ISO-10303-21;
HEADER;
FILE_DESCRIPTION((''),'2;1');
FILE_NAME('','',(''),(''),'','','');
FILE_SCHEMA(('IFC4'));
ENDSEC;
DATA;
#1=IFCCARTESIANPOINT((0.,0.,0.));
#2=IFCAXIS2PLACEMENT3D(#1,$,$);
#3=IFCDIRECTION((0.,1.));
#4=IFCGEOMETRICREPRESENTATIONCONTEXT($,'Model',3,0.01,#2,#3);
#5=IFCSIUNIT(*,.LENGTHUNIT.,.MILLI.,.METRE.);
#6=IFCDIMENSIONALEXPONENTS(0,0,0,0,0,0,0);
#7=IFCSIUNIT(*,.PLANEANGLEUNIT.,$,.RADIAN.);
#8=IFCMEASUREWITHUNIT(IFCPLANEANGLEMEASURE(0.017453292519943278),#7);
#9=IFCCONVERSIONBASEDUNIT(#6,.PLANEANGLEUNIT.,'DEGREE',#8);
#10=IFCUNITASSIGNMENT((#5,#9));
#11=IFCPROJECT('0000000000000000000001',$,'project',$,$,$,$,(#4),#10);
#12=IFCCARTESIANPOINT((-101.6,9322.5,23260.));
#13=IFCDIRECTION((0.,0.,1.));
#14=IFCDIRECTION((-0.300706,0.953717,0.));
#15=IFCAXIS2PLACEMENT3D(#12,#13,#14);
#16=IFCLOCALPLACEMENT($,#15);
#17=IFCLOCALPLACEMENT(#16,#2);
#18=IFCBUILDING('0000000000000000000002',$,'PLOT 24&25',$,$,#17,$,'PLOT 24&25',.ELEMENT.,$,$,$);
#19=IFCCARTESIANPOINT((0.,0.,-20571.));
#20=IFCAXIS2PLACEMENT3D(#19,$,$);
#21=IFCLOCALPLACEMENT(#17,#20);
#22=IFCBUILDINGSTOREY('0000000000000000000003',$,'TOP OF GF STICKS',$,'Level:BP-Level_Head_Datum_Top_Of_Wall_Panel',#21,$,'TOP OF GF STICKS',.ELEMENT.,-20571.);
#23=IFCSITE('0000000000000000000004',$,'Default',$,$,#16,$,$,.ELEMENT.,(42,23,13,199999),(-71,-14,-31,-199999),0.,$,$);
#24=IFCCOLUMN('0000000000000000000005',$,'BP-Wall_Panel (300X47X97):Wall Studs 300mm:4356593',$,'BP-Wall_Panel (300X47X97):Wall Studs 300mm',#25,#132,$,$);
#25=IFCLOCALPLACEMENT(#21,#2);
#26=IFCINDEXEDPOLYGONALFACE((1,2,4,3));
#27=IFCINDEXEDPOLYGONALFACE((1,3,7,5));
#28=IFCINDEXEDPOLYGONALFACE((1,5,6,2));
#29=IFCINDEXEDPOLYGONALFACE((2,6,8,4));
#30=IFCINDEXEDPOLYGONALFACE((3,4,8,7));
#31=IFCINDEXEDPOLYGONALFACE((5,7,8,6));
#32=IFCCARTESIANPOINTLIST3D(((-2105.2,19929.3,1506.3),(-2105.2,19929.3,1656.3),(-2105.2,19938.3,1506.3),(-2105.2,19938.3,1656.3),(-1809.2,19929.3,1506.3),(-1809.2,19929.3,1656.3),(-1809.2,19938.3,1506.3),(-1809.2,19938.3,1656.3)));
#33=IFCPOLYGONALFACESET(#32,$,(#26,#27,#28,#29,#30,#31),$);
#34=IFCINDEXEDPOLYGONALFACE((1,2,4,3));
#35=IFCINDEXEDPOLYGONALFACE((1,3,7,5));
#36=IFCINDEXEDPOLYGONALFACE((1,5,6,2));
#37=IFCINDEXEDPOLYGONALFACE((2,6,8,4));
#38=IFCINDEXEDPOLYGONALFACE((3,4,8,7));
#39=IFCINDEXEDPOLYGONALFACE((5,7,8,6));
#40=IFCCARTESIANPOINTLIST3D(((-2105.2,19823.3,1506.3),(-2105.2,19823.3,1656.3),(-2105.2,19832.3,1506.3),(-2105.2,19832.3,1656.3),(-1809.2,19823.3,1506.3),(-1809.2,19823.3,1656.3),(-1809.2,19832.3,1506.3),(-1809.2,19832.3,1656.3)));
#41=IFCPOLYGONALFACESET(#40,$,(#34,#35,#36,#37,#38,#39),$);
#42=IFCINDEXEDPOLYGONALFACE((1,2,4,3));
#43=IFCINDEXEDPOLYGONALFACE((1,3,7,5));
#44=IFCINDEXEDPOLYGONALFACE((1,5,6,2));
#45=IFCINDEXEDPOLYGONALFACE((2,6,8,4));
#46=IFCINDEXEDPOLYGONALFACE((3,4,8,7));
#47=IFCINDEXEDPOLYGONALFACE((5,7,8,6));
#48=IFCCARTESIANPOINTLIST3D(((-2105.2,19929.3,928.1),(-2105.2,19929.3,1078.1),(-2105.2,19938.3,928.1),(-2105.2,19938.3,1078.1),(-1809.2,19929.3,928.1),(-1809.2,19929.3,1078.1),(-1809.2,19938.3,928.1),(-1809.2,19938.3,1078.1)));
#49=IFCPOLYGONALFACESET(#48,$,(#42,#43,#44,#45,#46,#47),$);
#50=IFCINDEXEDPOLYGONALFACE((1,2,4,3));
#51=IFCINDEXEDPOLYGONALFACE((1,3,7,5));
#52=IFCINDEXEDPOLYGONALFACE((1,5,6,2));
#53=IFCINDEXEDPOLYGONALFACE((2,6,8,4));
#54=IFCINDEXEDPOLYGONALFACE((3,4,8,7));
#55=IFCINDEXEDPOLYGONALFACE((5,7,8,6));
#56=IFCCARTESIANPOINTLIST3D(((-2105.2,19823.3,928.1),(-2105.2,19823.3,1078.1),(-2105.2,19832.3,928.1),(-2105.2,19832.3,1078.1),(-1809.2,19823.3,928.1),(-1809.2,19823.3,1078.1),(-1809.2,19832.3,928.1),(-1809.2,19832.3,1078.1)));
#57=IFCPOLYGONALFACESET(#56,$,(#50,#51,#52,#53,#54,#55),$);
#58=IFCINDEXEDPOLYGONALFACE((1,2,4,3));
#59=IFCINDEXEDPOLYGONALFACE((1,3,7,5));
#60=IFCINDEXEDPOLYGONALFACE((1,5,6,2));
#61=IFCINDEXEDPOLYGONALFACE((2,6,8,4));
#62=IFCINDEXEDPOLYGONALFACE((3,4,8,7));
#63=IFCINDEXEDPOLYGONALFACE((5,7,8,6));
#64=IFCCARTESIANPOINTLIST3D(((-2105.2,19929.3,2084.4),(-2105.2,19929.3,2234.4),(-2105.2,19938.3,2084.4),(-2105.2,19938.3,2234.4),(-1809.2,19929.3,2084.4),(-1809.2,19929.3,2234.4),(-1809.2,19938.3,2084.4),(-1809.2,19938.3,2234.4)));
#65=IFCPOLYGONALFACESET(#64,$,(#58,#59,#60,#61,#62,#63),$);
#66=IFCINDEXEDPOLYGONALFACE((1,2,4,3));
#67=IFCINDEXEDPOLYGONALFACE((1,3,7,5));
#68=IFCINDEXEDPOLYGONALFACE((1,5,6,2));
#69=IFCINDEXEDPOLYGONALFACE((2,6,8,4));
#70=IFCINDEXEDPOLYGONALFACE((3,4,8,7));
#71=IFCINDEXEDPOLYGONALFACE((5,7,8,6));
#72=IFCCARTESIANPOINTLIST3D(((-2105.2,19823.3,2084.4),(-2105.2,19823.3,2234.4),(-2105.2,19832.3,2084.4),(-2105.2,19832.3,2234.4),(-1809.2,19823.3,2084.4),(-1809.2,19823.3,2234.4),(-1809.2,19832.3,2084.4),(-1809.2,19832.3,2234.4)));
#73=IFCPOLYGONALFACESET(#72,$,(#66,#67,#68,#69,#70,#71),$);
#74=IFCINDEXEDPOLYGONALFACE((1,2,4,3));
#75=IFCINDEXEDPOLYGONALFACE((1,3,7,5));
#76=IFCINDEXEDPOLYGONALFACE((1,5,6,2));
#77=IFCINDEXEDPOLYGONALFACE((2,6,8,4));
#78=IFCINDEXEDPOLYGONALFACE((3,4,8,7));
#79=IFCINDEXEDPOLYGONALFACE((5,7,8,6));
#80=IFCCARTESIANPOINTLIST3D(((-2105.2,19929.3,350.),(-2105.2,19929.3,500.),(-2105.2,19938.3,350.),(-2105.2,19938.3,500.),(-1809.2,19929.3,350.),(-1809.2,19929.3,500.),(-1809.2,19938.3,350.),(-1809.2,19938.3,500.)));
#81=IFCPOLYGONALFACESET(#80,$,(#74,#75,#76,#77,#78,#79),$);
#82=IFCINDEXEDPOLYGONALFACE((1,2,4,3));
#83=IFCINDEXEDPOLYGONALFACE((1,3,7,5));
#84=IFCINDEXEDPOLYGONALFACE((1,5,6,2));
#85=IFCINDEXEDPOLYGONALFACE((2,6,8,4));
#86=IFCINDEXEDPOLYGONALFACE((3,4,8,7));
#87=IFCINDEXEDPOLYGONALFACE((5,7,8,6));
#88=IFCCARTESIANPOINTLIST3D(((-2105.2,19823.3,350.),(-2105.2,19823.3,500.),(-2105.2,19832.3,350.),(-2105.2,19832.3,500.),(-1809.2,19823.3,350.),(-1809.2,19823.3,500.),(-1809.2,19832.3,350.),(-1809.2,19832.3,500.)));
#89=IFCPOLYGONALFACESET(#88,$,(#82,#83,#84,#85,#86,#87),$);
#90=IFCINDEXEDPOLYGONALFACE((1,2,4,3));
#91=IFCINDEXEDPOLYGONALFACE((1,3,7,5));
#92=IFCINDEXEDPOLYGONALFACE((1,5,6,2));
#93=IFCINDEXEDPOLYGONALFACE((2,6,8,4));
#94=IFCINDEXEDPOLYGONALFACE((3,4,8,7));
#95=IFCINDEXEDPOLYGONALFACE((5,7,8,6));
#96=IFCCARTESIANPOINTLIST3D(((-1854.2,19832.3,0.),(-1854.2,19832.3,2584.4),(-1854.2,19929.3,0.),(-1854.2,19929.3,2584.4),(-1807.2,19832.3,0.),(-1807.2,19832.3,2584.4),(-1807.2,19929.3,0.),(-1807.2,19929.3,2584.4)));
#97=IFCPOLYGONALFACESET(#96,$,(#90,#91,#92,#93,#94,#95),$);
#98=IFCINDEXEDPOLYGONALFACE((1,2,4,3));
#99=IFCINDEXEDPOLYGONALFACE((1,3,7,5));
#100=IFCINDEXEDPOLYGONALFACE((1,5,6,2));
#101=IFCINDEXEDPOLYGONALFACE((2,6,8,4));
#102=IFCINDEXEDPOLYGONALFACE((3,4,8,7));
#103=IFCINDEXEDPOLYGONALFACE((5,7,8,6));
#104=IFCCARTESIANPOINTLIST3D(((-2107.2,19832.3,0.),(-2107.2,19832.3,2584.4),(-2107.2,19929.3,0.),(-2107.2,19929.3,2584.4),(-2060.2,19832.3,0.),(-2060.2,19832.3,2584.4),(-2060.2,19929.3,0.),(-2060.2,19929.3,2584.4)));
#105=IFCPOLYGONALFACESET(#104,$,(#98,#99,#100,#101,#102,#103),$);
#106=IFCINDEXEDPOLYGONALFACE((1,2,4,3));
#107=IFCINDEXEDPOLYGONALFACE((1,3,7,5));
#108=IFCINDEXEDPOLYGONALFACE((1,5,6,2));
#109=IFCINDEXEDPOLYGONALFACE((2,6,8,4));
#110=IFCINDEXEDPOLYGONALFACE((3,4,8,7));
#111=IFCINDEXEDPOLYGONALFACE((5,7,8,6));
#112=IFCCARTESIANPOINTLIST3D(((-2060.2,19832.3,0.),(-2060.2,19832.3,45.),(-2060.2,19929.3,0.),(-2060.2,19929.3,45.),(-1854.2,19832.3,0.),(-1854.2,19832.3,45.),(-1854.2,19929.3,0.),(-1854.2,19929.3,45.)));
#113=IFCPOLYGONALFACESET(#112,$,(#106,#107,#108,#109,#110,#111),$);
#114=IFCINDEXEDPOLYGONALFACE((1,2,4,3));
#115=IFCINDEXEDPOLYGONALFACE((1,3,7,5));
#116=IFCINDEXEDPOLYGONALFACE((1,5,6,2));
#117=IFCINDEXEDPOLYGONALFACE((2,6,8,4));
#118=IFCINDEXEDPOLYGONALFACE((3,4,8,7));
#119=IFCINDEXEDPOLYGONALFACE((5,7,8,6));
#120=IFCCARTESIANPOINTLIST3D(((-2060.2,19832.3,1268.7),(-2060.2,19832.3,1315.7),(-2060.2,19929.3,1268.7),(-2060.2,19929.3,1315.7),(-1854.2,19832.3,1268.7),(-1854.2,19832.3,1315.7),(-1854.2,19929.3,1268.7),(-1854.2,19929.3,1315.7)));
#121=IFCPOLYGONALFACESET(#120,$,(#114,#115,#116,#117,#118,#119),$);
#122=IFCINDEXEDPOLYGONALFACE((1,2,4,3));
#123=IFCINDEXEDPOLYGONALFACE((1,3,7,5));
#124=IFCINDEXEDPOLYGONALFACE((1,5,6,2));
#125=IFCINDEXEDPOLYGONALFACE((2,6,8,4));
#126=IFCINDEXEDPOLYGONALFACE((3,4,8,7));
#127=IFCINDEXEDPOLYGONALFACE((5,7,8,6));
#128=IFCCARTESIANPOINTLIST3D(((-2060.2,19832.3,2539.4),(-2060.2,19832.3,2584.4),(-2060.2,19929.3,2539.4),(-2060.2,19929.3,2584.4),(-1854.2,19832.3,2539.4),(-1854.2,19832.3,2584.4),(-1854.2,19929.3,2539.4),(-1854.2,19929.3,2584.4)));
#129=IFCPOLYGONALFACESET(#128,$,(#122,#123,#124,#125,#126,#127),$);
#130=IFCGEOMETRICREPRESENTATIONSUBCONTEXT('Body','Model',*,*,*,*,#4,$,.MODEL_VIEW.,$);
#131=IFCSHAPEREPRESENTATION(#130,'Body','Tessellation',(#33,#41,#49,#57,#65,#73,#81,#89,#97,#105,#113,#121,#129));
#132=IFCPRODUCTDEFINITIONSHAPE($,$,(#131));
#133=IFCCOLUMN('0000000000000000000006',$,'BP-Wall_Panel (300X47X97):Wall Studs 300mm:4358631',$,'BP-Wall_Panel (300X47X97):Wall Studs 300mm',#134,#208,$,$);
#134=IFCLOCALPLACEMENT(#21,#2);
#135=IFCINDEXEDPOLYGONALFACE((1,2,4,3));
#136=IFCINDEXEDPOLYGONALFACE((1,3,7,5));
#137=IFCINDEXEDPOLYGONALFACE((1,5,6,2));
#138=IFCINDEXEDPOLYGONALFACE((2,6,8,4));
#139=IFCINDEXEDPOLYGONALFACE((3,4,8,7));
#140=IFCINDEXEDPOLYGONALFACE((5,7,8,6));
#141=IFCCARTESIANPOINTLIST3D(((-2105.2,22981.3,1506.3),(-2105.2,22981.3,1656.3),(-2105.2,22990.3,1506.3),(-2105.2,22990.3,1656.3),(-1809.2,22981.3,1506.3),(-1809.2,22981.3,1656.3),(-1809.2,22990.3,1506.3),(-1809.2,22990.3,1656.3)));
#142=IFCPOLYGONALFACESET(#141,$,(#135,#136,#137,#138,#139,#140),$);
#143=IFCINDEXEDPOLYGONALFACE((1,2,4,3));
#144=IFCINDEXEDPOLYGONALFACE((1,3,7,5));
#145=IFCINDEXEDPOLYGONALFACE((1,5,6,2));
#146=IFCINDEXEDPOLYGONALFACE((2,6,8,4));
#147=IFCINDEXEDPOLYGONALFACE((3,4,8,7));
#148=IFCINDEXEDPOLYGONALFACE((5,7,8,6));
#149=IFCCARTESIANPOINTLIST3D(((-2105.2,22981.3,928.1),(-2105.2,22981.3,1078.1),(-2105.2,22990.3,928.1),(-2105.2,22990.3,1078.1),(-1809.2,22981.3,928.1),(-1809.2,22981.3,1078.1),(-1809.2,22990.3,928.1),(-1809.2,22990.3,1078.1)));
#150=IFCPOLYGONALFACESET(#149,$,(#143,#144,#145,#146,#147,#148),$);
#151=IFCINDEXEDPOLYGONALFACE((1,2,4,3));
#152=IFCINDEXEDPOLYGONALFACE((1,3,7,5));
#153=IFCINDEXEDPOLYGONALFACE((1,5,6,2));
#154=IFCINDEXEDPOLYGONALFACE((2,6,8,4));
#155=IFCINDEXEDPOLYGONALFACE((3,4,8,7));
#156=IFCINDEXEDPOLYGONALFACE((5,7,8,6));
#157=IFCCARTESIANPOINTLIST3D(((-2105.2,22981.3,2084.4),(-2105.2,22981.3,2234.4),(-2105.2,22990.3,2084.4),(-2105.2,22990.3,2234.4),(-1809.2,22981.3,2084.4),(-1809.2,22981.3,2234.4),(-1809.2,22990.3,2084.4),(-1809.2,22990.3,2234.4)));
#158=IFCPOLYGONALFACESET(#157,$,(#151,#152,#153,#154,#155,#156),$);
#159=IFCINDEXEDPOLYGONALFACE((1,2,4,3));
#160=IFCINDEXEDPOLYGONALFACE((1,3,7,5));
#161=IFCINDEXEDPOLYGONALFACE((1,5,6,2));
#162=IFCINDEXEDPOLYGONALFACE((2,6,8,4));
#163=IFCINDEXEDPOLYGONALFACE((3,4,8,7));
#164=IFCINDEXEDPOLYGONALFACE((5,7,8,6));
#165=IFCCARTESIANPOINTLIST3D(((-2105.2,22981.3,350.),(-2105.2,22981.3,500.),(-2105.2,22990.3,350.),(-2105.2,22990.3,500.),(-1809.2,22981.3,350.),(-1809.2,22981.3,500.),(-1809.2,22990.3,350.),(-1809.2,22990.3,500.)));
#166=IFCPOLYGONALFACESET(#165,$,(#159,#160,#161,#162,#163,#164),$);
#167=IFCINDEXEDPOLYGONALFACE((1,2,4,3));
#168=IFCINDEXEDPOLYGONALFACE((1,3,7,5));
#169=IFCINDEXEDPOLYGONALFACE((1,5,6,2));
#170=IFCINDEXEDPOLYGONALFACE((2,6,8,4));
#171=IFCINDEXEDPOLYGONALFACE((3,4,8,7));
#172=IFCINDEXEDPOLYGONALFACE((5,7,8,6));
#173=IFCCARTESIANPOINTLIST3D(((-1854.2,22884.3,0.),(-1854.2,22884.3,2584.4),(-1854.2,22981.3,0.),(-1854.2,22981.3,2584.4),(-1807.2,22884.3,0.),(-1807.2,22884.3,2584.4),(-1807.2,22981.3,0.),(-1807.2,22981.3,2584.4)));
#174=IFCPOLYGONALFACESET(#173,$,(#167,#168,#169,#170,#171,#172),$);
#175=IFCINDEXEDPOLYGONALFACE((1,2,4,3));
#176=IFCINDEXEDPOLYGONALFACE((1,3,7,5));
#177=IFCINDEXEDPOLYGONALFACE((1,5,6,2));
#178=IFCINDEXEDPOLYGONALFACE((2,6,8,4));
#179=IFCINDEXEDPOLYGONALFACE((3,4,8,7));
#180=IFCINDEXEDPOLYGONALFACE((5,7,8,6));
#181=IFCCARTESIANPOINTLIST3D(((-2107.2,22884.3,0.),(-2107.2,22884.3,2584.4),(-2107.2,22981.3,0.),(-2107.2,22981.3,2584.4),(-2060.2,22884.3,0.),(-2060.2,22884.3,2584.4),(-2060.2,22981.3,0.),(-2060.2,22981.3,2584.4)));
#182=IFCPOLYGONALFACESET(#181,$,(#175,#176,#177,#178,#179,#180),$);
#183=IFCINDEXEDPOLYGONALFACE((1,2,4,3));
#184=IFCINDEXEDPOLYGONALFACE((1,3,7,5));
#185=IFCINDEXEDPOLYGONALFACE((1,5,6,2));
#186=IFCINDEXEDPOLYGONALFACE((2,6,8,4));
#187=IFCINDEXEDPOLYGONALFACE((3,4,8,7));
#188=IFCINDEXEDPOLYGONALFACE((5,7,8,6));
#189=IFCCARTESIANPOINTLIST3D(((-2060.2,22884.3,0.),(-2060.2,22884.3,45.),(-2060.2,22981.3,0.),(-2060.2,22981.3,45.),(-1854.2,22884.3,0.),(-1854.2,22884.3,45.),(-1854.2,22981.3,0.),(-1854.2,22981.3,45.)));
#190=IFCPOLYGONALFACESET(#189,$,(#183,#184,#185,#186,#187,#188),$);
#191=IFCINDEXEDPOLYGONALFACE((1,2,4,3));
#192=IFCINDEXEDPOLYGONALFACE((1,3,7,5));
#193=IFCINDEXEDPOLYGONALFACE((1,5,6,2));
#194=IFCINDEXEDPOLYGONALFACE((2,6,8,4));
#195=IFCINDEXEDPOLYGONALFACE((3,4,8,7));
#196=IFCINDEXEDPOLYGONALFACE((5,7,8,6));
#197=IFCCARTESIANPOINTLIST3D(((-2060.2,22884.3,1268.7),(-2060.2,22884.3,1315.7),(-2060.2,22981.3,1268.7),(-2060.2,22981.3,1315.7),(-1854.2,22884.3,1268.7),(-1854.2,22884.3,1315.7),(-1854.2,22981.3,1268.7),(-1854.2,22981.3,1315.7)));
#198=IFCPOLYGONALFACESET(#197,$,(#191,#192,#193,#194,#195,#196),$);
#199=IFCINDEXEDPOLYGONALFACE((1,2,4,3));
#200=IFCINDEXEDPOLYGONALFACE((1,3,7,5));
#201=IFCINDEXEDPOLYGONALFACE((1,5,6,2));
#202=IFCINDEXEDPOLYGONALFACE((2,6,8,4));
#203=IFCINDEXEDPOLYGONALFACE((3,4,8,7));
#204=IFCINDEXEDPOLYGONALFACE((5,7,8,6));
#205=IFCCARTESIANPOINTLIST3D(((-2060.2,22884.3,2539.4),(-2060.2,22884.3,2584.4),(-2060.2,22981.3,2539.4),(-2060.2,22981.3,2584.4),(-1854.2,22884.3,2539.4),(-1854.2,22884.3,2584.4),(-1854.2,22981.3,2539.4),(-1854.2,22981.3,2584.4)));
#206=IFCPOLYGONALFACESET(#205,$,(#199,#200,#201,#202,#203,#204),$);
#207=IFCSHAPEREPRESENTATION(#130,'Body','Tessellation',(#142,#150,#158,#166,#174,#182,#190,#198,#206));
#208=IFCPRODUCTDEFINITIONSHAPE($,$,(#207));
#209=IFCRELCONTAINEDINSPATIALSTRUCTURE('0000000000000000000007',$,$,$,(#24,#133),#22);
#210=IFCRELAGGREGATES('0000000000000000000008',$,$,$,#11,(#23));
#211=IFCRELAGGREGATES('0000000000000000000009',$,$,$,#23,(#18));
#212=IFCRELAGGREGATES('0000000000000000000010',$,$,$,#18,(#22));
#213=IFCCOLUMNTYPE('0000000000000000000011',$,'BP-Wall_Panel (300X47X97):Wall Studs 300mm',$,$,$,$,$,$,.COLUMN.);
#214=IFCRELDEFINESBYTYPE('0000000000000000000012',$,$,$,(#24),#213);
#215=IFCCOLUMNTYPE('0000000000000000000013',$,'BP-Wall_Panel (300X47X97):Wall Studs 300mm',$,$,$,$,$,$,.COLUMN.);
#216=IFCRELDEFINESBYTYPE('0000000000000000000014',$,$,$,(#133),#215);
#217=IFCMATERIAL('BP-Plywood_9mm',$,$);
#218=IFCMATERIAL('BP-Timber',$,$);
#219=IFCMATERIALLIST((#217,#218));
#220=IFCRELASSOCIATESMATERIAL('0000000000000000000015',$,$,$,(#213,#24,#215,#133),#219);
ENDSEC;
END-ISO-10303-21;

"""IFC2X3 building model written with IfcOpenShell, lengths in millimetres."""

from ifc_helpers import new_model, entity, si_unit, converted_unit, direction, frame, frame_2d, origin, origin_2d_with_axis, place, context, subcontext, project, spatial, rectangle, extrude, source, transform, mapped, material, material_list, type_object, type_shapes, element, save


model = new_model("IFC2X3")

# Units and contexts
model_context = context("Model", 3, precision=0.01, world=origin(), true_north=direction((0.0, 1.0)))
body_context = subcontext(model_context, "Body", "Model", "MODEL_VIEW")
ifc_project = project(units=[si_unit("LENGTHUNIT", "METRE", prefix="MILLI"), converted_unit("PLANEANGLEUNIT", "DEGREE", entity("IfcPlaneAngleMeasure", 0.017453292519943278), si_unit("PLANEANGLEUNIT", "RADIAN"), dimensions=[0, 0, 0, 0, 0, 0, 0])], contexts=[model_context])

# Site, building, storey
site_placement = place(None, frame((-101.6, 9322.5, 23260.0), z_axis=(0.0, 0.0, 1.0), x_axis=(-0.300706, 0.953717, 0.0)))
site = spatial("IfcSite", under=ifc_project, at=site_placement, Name="Default", CompositionType="ELEMENT", RefLatitude=(42, 23, 13, 199999), RefLongitude=(-71, -14, -31, -199999), RefElevation=0.0)
building_placement = place(site_placement, origin())
building = spatial("IfcBuilding", under=site, at=building_placement, Name="PLOT 24&25", LongName="PLOT 24&25", CompositionType="ELEMENT")
storey_placement = place(building_placement, frame((0.0, 0.0, -20571.0)))
storey = spatial("IfcBuildingStorey", under=building, at=storey_placement, Name="TOP OF GF STICKS", ObjectType="Level:BP-Level_Head_Datum_Top_Of_Wall_Panel", LongName="TOP OF GF STICKS", CompositionType="ELEMENT", Elevation=-20571.0)

# Columns
ifc_material_1 = material(Name="BP-Plywood_9mm")
ifc_material_2 = material(Name="BP-Timber")
ifc_material_list = material_list([ifc_material_1, ifc_material_2])
column_type_1 = type_object("IfcColumnType", Name="BP-Wall_Panel (300X47X97):Wall Studs 300mm", PredefinedType="COLUMN", material=ifc_material_list)
shared_shape_1 = source(origin(), body_context, "Body", "SweptSolid", [
    extrude(rectangle(XDim=296.0, YDim=9.0, at=origin_2d_with_axis()), frame((53.0, 0.0, -19064.7), z_axis=(0.0, 0.0, 1.0), x_axis=(0.0, -1.0, 0.0)), (0.0, 0.0, 1.0), 150.0),
    extrude(rectangle(XDim=9.0, YDim=296.0, at=origin_2d_with_axis()), frame((-53.0, 0.0, -19064.7), z_axis=(0.0, 0.0, 1.0), x_axis=(-1.0, 0.0, 0.0)), (0.0, 0.0, 1.0), 150.0),
    extrude(rectangle(XDim=296.0, YDim=9.0, at=origin_2d_with_axis()), frame((53.0, 0.0, -19642.9), z_axis=(0.0, 0.0, 1.0), x_axis=(0.0, -1.0, 0.0)), (0.0, 0.0, 1.0), 150.0),
    extrude(rectangle(XDim=9.0, YDim=296.0, at=origin_2d_with_axis()), frame((-53.0, 0.0, -19642.9), z_axis=(0.0, 0.0, 1.0), x_axis=(-1.0, 0.0, 0.0)), (0.0, 0.0, 1.0), 150.0),
    extrude(rectangle(XDim=296.0, YDim=9.0, at=origin_2d_with_axis()), frame((53.0, 0.0, -18486.6), z_axis=(0.0, 0.0, 1.0), x_axis=(0.0, -1.0, 0.0)), (0.0, 0.0, 1.0), 150.0),
    extrude(rectangle(XDim=9.0, YDim=296.0, at=origin_2d_with_axis()), frame((-53.0, 0.0, -18486.6), z_axis=(0.0, 0.0, 1.0), x_axis=(-1.0, 0.0, 0.0)), (0.0, 0.0, 1.0), 150.0),
    extrude(rectangle(XDim=296.0, YDim=9.0, at=origin_2d_with_axis()), frame((53.0, 0.0, -20221.0), z_axis=(0.0, 0.0, 1.0), x_axis=(0.0, -1.0, 0.0)), (0.0, 0.0, 1.0), 150.0),
    extrude(rectangle(XDim=9.0, YDim=296.0, at=origin_2d_with_axis()), frame((-53.0, 0.0, -20221.0), z_axis=(0.0, 0.0, 1.0), x_axis=(-1.0, 0.0, 0.0)), (0.0, 0.0, 1.0), 150.0),
    extrude(rectangle(XDim=97.0, YDim=47.0, at=origin_2d_with_axis()), frame((0.0, -126.5, -20571.0), z_axis=(0.0, 0.0, 1.0), x_axis=(-1.0, 0.0, 0.0)), (0.0, 0.0, 1.0), 2584.4),
    extrude(rectangle(XDim=97.0, YDim=47.0, at=frame_2d((0.0, 0.0), x_axis=(1.0, 0.0))), frame((0.0, 126.5, -20571.0), z_axis=(0.0, 0.0, 1.0), x_axis=(-1.0, 0.0, 0.0)), (0.0, 0.0, 1.0), 2584.4),
    extrude(rectangle(XDim=206.0, YDim=97.0, at=origin_2d_with_axis()), frame((0.0, 0.0, -20571.0), z_axis=(0.0, 0.0, 1.0), x_axis=(0.0, -1.0, 0.0)), (0.0, 0.0, 1.0), 45.0),
    extrude(rectangle(XDim=206.0, YDim=97.0, at=origin_2d_with_axis()), frame((0.0, 0.0, -19302.3), z_axis=(0.0, 0.0, 1.0), x_axis=(0.0, -1.0, 0.0)), (0.0, 0.0, 1.0), 47.0),
    extrude(rectangle(XDim=206.0, YDim=97.0, at=origin_2d_with_axis()), frame((0.0, 0.0, -18031.6), z_axis=(0.0, 0.0, 1.0), x_axis=(0.0, -1.0, 0.0)), (0.0, 0.0, 1.0), 45.0),
])
type_shapes(column_type_1, [shared_shape_1])
for number, where, z_axis, x_axis, name in (
    (1, (-1957.2, 19880.8, 20571.0), (0.0, 0.0, 1.0), (0.0, 1.0, 0.0), "BP-Wall_Panel (300X47X97):Wall Studs 300mm:4356593"),
):
    element("IfcColumn", number, at=place(storey_placement, frame(where, z_axis=z_axis, x_axis=x_axis)), inside=storey, type_object=column_type_1, material=ifc_material_list, Name=name, ObjectType="BP-Wall_Panel (300X47X97):Wall Studs 300mm", context=body_context, shape_type="MappedRepresentation", body=[
        mapped(shared_shape_1, transform((0.0, 0.0, 0.0), scale=1.0)),
    ])
column_type_2 = type_object("IfcColumnType", Name="BP-Wall_Panel (300X47X97):Wall Studs 300mm", PredefinedType="COLUMN", material=ifc_material_list)
shared_shape_2 = source(origin(), body_context, "Body", "SweptSolid", [
    extrude(rectangle(XDim=296.0, YDim=9.0, at=origin_2d_with_axis()), frame((53.0, 0.0, -19064.7), z_axis=(0.0, 0.0, 1.0), x_axis=(0.0, -1.0, 0.0)), (0.0, 0.0, 1.0), 150.0),
    extrude(rectangle(XDim=296.0, YDim=9.0, at=origin_2d_with_axis()), frame((53.0, 0.0, -19642.9), z_axis=(0.0, 0.0, 1.0), x_axis=(0.0, -1.0, 0.0)), (0.0, 0.0, 1.0), 150.0),
    extrude(rectangle(XDim=296.0, YDim=9.0, at=origin_2d_with_axis()), frame((53.0, 0.0, -18486.6), z_axis=(0.0, 0.0, 1.0), x_axis=(0.0, -1.0, 0.0)), (0.0, 0.0, 1.0), 150.0),
    extrude(rectangle(XDim=296.0, YDim=9.0, at=origin_2d_with_axis()), frame((53.0, 0.0, -20221.0), z_axis=(0.0, 0.0, 1.0), x_axis=(0.0, -1.0, 0.0)), (0.0, 0.0, 1.0), 150.0),
    extrude(rectangle(XDim=97.0, YDim=47.0, at=origin_2d_with_axis()), frame((0.0, -126.5, -20571.0), z_axis=(0.0, 0.0, 1.0), x_axis=(-1.0, 0.0, 0.0)), (0.0, 0.0, 1.0), 2584.4),
    extrude(rectangle(XDim=97.0, YDim=47.0, at=frame_2d((0.0, 0.0), x_axis=(1.0, 0.0))), frame((0.0, 126.5, -20571.0), z_axis=(0.0, 0.0, 1.0), x_axis=(-1.0, 0.0, 0.0)), (0.0, 0.0, 1.0), 2584.4),
    extrude(rectangle(XDim=206.0, YDim=97.0, at=origin_2d_with_axis()), frame((0.0, 0.0, -20571.0), z_axis=(0.0, 0.0, 1.0), x_axis=(0.0, -1.0, 0.0)), (0.0, 0.0, 1.0), 45.0),
    extrude(rectangle(XDim=206.0, YDim=97.0, at=origin_2d_with_axis()), frame((0.0, 0.0, -19302.3), z_axis=(0.0, 0.0, 1.0), x_axis=(0.0, -1.0, 0.0)), (0.0, 0.0, 1.0), 47.0),
    extrude(rectangle(XDim=206.0, YDim=97.0, at=origin_2d_with_axis()), frame((0.0, 0.0, -18031.6), z_axis=(0.0, 0.0, 1.0), x_axis=(0.0, -1.0, 0.0)), (0.0, 0.0, 1.0), 45.0),
])
type_shapes(column_type_2, [shared_shape_2])
column_1_placement = place(storey_placement, frame((-1957.2, 22932.8, 20571.0), z_axis=(0.0, 0.0, 1.0), x_axis=(0.0, 1.0, 0.0)))
element("IfcColumn", 2, at=column_1_placement, inside=storey, type_object=column_type_2, material=ifc_material_list, Name="BP-Wall_Panel (300X47X97):Wall Studs 300mm:4358631", ObjectType="BP-Wall_Panel (300X47X97):Wall Studs 300mm", context=body_context, shape_type="MappedRepresentation", body=[
    mapped(shared_shape_2, transform((0.0, 0.0, 0.0), scale=1.0)),
])

save(model, "model.ifc")
